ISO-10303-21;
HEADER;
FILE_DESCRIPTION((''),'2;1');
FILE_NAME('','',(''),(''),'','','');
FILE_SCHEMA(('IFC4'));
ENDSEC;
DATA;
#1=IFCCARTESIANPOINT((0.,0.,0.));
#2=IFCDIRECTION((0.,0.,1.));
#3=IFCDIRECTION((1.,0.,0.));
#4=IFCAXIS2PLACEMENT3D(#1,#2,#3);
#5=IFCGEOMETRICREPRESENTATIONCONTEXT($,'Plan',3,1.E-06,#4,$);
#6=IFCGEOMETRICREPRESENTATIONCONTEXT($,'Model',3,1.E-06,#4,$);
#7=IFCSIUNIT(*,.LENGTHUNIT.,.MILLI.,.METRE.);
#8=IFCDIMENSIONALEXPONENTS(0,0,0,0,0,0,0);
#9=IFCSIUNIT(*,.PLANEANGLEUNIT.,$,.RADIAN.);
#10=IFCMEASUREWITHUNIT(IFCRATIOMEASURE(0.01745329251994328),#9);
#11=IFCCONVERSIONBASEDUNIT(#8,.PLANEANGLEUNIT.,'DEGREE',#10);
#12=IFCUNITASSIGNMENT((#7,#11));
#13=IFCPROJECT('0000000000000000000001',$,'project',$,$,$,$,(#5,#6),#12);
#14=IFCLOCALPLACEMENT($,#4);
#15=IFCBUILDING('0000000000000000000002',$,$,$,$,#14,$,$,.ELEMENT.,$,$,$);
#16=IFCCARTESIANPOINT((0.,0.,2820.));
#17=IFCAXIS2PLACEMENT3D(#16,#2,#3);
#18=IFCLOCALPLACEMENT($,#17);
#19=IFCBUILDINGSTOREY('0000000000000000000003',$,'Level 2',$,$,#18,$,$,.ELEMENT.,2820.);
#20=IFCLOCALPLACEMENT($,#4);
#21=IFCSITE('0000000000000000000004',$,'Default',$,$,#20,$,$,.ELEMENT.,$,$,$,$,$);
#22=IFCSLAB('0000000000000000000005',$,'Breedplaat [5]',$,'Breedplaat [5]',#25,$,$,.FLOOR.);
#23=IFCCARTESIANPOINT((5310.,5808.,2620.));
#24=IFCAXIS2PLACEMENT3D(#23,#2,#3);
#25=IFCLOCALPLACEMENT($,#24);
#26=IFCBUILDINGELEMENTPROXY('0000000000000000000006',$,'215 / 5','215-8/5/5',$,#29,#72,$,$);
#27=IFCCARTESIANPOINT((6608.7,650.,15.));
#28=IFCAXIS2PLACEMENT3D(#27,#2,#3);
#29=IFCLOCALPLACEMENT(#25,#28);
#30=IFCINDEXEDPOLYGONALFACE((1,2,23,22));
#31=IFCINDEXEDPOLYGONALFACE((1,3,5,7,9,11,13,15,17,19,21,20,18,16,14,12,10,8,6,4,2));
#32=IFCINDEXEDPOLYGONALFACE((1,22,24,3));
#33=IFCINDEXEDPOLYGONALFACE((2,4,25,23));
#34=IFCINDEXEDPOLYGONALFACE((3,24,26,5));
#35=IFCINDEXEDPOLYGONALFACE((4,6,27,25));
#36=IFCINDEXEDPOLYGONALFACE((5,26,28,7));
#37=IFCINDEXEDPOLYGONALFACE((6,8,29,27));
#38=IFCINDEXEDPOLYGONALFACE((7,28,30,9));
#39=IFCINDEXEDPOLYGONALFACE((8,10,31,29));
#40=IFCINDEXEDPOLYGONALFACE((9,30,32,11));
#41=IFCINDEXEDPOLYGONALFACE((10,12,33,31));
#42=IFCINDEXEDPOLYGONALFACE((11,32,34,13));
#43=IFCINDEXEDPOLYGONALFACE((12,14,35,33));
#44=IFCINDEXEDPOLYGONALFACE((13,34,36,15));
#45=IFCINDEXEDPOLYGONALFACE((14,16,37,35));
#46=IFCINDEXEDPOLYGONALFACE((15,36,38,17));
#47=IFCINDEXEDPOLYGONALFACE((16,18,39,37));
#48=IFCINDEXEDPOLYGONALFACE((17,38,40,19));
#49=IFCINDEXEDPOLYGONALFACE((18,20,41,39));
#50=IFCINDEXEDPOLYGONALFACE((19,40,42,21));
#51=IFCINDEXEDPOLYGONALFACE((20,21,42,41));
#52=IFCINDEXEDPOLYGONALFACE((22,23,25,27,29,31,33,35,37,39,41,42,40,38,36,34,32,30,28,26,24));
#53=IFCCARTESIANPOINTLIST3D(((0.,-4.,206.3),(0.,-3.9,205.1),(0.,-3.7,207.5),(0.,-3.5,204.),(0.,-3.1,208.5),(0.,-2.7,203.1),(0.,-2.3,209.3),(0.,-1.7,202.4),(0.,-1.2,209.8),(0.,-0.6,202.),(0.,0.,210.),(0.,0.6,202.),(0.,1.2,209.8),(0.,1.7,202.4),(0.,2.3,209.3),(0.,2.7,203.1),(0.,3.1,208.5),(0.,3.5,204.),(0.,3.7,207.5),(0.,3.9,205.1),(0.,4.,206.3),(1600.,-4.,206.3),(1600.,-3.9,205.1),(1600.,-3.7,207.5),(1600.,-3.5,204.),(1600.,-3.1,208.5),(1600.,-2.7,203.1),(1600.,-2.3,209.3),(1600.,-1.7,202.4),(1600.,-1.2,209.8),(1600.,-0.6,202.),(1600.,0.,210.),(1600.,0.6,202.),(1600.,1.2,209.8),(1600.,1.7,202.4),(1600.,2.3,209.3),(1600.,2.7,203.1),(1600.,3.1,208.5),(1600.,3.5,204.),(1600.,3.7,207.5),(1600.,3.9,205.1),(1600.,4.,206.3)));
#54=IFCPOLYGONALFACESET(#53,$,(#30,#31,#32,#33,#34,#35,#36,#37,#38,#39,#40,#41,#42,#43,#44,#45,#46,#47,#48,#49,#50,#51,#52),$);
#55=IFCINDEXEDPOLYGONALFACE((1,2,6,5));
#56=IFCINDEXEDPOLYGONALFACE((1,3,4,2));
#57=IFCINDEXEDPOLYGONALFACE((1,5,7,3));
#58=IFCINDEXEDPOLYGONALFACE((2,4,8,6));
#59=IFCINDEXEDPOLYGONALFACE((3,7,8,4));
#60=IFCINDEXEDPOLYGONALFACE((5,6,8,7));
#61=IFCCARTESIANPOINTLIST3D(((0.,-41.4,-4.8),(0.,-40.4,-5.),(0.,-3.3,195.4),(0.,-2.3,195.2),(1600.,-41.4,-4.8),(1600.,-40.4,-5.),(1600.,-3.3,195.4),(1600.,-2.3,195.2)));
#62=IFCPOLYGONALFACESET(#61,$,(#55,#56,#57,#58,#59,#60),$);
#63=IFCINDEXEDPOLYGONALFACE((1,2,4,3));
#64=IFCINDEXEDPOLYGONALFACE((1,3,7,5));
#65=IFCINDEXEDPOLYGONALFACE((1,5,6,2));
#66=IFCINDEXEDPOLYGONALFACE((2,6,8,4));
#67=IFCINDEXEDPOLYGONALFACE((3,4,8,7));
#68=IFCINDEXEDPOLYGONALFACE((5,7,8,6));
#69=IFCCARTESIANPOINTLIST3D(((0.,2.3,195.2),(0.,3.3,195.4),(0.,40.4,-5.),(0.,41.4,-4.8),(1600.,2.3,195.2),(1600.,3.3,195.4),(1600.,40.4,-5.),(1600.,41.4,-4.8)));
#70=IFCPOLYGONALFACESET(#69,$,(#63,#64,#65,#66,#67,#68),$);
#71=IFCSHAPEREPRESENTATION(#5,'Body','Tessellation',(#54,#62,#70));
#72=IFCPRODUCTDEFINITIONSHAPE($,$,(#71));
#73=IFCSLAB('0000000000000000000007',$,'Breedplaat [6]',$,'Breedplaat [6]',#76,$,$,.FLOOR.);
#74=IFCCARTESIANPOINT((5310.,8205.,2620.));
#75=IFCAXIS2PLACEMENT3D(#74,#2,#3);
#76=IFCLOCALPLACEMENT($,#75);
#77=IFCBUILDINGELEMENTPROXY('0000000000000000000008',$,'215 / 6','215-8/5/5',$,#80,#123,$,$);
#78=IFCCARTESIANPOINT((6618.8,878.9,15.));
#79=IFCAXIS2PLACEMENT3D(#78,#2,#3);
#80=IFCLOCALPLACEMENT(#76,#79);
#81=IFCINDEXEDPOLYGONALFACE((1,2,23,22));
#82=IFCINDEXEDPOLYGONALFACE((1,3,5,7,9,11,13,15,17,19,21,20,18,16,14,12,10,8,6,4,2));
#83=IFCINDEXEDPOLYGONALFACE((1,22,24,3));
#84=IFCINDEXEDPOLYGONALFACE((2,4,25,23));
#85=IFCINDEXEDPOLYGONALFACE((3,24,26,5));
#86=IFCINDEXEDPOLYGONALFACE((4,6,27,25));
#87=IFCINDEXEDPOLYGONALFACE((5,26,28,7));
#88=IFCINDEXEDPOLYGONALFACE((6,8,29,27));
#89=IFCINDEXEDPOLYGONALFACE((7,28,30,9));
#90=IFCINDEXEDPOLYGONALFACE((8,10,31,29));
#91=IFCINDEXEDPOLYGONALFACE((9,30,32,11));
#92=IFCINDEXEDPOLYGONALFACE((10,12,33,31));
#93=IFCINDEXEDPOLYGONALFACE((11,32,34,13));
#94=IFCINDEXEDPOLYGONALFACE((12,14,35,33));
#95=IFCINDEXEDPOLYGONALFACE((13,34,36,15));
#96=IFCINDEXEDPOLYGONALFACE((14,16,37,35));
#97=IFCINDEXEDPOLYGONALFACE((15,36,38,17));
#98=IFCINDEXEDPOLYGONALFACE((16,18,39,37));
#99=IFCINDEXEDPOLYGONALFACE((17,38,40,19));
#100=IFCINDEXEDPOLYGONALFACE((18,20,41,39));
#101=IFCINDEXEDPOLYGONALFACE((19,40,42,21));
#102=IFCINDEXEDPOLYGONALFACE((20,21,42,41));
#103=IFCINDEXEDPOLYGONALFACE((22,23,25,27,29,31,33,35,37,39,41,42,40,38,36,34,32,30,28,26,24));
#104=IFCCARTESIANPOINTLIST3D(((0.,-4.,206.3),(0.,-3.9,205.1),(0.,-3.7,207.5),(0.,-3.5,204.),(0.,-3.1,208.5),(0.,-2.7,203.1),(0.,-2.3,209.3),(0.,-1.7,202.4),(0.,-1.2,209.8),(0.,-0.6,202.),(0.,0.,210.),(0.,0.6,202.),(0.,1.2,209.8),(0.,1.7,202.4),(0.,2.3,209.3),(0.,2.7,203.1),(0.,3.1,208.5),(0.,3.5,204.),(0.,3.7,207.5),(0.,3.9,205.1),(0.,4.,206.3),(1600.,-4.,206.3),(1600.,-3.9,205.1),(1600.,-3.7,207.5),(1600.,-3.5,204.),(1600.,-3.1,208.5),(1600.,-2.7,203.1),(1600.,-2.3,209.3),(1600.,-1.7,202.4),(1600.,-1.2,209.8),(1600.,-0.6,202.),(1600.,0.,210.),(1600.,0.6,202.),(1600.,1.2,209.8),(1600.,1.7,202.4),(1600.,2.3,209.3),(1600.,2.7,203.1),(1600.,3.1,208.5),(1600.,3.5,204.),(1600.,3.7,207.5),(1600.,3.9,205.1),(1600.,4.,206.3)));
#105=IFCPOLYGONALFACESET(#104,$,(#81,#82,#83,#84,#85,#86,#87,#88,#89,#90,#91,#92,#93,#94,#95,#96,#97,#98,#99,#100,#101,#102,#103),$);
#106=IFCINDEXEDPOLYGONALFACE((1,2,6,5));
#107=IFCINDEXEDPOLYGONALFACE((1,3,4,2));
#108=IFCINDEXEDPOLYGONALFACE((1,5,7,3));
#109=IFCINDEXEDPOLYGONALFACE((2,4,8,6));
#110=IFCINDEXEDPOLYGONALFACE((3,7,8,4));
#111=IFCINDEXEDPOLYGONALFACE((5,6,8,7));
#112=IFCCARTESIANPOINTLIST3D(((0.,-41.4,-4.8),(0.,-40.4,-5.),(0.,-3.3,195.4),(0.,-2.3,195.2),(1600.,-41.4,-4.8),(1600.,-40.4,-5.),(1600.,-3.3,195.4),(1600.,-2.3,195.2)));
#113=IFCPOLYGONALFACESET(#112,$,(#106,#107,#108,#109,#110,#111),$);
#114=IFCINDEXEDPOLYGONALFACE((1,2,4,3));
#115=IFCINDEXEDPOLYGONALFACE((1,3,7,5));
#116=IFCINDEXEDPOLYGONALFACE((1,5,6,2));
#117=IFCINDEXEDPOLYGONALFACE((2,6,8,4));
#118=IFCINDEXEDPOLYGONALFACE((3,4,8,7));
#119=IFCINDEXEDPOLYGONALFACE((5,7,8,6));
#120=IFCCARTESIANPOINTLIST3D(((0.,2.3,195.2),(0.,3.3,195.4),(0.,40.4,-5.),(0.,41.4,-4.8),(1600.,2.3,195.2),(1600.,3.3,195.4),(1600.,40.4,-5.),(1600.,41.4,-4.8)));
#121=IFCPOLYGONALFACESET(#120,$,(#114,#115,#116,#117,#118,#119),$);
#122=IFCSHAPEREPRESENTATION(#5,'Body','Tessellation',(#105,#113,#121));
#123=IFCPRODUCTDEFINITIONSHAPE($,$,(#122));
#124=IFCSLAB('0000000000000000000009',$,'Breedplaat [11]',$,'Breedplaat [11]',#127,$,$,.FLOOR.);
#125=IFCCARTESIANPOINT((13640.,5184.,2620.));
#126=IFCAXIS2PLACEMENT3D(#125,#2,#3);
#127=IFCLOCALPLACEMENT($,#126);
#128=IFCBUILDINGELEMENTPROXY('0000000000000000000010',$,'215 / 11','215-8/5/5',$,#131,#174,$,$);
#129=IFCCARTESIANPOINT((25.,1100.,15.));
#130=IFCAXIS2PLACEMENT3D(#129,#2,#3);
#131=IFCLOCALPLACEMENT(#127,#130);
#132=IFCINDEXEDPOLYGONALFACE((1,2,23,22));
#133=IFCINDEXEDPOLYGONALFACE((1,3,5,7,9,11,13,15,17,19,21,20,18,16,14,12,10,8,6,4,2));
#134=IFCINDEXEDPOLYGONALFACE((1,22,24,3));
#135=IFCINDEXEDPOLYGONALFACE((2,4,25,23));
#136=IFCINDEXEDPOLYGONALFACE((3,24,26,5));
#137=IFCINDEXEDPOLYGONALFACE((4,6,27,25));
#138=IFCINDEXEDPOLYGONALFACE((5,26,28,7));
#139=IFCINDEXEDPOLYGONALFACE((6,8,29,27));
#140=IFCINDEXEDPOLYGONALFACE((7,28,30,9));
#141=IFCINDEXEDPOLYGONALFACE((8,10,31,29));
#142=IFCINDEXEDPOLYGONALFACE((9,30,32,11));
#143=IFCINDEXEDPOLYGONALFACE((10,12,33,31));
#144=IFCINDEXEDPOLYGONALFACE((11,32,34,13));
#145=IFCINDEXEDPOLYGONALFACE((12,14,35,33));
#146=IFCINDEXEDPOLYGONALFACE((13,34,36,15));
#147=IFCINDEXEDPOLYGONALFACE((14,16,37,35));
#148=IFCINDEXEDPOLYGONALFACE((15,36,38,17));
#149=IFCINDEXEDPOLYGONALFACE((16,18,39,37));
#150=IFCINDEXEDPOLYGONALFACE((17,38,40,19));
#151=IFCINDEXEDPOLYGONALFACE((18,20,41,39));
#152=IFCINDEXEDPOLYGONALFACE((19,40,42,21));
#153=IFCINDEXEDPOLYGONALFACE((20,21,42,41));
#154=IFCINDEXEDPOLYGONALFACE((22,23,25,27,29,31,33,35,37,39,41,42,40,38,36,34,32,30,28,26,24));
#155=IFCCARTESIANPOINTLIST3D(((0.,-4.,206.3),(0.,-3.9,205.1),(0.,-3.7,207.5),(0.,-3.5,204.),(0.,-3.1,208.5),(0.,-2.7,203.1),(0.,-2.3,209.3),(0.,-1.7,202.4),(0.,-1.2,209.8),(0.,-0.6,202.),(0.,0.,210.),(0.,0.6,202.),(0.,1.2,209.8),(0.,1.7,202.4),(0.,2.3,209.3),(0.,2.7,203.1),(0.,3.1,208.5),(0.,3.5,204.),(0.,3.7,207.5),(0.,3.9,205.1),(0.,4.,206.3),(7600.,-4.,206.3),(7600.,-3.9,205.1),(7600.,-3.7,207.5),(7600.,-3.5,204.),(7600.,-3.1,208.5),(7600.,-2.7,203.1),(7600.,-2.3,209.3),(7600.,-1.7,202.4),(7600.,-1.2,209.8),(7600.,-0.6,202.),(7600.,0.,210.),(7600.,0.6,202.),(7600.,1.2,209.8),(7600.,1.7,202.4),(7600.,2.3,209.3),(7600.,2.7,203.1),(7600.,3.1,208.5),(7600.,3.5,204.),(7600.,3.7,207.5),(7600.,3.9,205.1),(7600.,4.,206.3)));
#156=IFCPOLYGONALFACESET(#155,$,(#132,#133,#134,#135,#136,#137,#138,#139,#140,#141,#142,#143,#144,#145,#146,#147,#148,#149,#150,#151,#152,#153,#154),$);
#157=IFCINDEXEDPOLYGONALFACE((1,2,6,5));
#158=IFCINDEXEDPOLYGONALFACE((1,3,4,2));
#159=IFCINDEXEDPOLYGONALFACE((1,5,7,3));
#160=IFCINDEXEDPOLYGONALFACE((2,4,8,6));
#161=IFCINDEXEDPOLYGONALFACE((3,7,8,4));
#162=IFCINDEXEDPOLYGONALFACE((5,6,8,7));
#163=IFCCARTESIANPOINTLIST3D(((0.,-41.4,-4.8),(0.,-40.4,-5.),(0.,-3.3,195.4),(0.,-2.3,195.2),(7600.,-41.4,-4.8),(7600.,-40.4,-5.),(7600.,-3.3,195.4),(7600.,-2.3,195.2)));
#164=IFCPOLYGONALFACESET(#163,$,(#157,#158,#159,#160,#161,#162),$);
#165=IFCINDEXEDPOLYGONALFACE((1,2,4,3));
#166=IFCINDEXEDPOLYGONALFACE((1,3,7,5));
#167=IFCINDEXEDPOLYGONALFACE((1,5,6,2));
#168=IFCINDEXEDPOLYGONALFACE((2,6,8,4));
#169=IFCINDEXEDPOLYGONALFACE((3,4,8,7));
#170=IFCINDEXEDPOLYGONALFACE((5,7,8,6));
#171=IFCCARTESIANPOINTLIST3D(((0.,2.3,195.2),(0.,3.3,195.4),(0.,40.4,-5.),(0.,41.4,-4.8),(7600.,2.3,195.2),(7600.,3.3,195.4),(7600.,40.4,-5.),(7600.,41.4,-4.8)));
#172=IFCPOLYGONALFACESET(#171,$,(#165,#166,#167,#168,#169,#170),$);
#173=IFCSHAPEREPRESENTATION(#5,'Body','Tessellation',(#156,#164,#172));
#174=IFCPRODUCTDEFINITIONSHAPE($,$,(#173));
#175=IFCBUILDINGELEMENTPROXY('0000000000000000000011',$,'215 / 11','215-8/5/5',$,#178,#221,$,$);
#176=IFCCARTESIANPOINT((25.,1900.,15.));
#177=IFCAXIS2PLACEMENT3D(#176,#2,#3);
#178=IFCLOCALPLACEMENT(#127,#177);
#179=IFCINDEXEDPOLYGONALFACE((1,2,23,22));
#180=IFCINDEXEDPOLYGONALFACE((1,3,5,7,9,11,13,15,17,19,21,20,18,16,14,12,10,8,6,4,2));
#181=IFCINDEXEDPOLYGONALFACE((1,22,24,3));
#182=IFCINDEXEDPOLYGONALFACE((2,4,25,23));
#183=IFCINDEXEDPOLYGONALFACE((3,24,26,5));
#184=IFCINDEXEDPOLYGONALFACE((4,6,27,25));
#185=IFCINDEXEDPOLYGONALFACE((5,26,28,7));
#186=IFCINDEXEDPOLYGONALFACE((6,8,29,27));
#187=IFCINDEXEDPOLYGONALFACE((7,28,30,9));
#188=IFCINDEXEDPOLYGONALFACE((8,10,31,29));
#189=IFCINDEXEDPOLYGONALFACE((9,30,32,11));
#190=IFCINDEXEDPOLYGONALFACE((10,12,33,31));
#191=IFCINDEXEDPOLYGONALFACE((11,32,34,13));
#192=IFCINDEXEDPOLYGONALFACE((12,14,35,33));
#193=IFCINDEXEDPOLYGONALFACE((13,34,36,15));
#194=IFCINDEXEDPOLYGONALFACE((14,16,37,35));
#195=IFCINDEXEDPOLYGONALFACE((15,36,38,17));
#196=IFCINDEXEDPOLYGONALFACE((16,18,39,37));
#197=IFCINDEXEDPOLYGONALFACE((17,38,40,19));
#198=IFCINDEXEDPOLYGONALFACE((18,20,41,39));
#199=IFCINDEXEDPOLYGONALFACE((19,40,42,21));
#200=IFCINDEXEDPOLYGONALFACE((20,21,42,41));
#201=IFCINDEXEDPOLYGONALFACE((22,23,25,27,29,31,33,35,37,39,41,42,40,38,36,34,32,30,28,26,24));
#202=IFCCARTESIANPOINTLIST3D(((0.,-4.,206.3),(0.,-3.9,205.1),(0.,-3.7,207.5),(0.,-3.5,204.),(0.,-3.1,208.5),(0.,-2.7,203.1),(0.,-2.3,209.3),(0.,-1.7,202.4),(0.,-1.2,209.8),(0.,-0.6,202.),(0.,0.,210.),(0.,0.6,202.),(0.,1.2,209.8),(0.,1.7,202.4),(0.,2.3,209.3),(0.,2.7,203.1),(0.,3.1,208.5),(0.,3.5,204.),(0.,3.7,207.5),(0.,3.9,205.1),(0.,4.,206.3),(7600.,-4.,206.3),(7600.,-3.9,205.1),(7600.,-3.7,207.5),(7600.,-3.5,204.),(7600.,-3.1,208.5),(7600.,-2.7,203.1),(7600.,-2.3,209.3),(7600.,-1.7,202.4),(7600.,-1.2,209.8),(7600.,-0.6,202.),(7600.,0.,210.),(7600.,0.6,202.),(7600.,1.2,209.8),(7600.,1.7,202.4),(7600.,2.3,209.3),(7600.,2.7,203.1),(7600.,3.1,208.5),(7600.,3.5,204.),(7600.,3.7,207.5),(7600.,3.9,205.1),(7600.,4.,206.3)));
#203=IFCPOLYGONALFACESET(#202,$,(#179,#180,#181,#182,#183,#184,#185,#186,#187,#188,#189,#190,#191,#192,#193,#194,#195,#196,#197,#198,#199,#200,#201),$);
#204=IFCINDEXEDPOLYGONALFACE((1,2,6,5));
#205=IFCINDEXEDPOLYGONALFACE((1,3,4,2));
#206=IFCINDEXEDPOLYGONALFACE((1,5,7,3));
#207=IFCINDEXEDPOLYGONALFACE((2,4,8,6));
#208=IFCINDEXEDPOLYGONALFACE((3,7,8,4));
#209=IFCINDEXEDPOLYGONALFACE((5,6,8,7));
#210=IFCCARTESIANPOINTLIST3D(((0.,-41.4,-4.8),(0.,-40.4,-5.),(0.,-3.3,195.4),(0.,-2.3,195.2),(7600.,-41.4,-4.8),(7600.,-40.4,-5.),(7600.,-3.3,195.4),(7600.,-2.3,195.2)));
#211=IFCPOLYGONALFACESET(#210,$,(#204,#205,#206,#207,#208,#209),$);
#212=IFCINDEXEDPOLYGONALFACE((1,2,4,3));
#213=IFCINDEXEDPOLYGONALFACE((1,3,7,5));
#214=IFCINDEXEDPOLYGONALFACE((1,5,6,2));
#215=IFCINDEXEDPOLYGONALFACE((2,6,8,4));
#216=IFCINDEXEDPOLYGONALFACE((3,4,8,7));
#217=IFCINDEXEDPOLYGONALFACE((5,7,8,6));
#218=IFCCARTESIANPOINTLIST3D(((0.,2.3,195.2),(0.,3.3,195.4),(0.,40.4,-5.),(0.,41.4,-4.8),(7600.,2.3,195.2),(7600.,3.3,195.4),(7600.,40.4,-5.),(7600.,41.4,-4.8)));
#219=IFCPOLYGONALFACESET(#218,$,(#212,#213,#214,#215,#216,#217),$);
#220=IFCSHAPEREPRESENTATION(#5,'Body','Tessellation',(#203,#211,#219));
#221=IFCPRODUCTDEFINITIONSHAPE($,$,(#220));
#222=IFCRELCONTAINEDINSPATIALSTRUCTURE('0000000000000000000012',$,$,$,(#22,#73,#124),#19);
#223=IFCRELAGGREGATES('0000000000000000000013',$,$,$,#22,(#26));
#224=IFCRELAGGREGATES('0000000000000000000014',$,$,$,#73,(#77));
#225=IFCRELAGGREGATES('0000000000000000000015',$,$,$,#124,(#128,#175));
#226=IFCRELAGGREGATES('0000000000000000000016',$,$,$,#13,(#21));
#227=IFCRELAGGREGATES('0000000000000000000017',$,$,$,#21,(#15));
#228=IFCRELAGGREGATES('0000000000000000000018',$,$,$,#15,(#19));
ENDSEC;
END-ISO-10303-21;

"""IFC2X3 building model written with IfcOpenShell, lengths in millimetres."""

from ifc_helpers import new_model, entity, si_unit, converted_unit, frame, origin_with_axes, origin_2d_with_axis, place, context, project, spatial, rectangle, circle, extrude, element, aggregate, save


model = new_model("IFC2X3")

# Units and contexts
plan_context = context("Plan", 3, precision=1e-06, world=origin_with_axes())
model_context = context("Model", 3, precision=1e-06, world=origin_with_axes())
ifc_project = project(units=[si_unit("LENGTHUNIT", "METRE", prefix="MILLI"), converted_unit("PLANEANGLEUNIT", "DEGREE", entity("IfcRatioMeasure", 0.01745329251994328), si_unit("PLANEANGLEUNIT", "RADIAN"), dimensions=[0, 0, 0, 0, 0, 0, 0])], contexts=[plan_context, model_context])

# Site, building, storey
site_placement = place(None, origin_with_axes())
site = spatial("IfcSite", under=ifc_project, at=site_placement, Name="Default", CompositionType="ELEMENT")
building_placement = place(None, origin_with_axes())
building = spatial("IfcBuilding", under=site, at=building_placement, CompositionType="ELEMENT")
storey_placement = place(None, frame((0.0, 0.0, 2820.0), z_axis=(0.0, 0.0, 1.0), x_axis=(1.0, 0.0, 0.0)))
storey = spatial("IfcBuildingStorey", under=building, at=storey_placement, Name="Level 2", CompositionType="ELEMENT", Elevation=2820.0)

# Slabs, building element proxies
slab_1_placement = place(None, frame((5310.0, 5808.0, 2620.0), z_axis=(0.0, 0.0, 1.0), x_axis=(1.0, 0.0, 0.0)))
slab_1 = element("IfcSlab", 1, at=slab_1_placement, inside=storey, Name="Breedplaat [5]", ObjectType="Breedplaat [5]", PredefinedType="FLOOR")
proxy_1_placement = place(slab_1_placement, frame((6608.7, 650.0, 15.0), z_axis=(0.0, 0.0, 1.0), x_axis=(1.0, 0.0, 0.0)))
proxy_1 = element("IfcBuildingElementProxy", 2, at=proxy_1_placement, Name="215 / 5", Description="215-8/5/5", context=plan_context, shape_type="SweptSolid", body=[
    extrude(circle(Radius=4.0, at=origin_2d_with_axis()), frame((0.0, 0.0, 206.0), z_axis=(1.0, 0.0, 0.0), x_axis=(0.0, 0.0, 1.0)), (0.0, 0.0, 1.0), 1600.0),
    extrude(rectangle(XDim=203.8, YDim=1.0, at=origin_2d_with_axis()), frame((0.0, -21.9, 95.2), z_axis=(1.0, 0.0, 0.0), x_axis=(0.0, 0.187112, 0.982339)), (0.0, 0.0, 1.0), 1600.0),
    extrude(rectangle(XDim=203.8, YDim=1.0, at=origin_2d_with_axis()), frame((0.0, 21.9, 95.2), z_axis=(1.0, 0.0, 0.0), x_axis=(0.0, -0.187112, 0.982339)), (0.0, 0.0, 1.0), 1600.0),
])
aggregate(slab_1, [proxy_1])
slab_2_placement = place(None, frame((5310.0, 8205.0, 2620.0), z_axis=(0.0, 0.0, 1.0), x_axis=(1.0, 0.0, 0.0)))
slab_2 = element("IfcSlab", 3, at=slab_2_placement, inside=storey, Name="Breedplaat [6]", ObjectType="Breedplaat [6]", PredefinedType="FLOOR")
proxy_2_placement = place(slab_2_placement, frame((6618.8, 878.9, 15.0), z_axis=(0.0, 0.0, 1.0), x_axis=(1.0, 0.0, 0.0)))
proxy_2 = element("IfcBuildingElementProxy", 4, at=proxy_2_placement, Name="215 / 6", Description="215-8/5/5", context=plan_context, shape_type="SweptSolid", body=[
    extrude(circle(Radius=4.0, at=origin_2d_with_axis()), frame((0.0, 0.0, 206.0), z_axis=(1.0, 0.0, 0.0), x_axis=(0.0, 0.0, 1.0)), (0.0, 0.0, 1.0), 1600.0),
    extrude(rectangle(XDim=203.8, YDim=1.0, at=origin_2d_with_axis()), frame((0.0, -21.9, 95.2), z_axis=(1.0, 0.0, 0.0), x_axis=(0.0, 0.187112, 0.982339)), (0.0, 0.0, 1.0), 1600.0),
    extrude(rectangle(XDim=203.8, YDim=1.0, at=origin_2d_with_axis()), frame((0.0, 21.9, 95.2), z_axis=(1.0, 0.0, 0.0), x_axis=(0.0, -0.187112, 0.982339)), (0.0, 0.0, 1.0), 1600.0),
])
aggregate(slab_2, [proxy_2])
slab_3_placement = place(None, frame((13640.0, 5184.0, 2620.0), z_axis=(0.0, 0.0, 1.0), x_axis=(1.0, 0.0, 0.0)))
slab_3 = element("IfcSlab", 5, at=slab_3_placement, inside=storey, Name="Breedplaat [11]", ObjectType="Breedplaat [11]", PredefinedType="FLOOR")
proxy_3_placement = place(slab_3_placement, frame((25.0, 1100.0, 15.0), z_axis=(0.0, 0.0, 1.0), x_axis=(1.0, 0.0, 0.0)))
proxy_3 = element("IfcBuildingElementProxy", 6, at=proxy_3_placement, Name="215 / 11", Description="215-8/5/5", context=plan_context, shape_type="SweptSolid", body=[
    extrude(circle(Radius=4.0, at=origin_2d_with_axis()), frame((0.0, 0.0, 206.0), z_axis=(1.0, 0.0, 0.0), x_axis=(0.0, 0.0, 1.0)), (0.0, 0.0, 1.0), 7600.0),
    extrude(rectangle(XDim=203.8, YDim=1.0, at=origin_2d_with_axis()), frame((0.0, -21.9, 95.2), z_axis=(1.0, 0.0, 0.0), x_axis=(0.0, 0.187112, 0.982339)), (0.0, 0.0, 1.0), 7600.0),
    extrude(rectangle(XDim=203.8, YDim=1.0, at=origin_2d_with_axis()), frame((0.0, 21.9, 95.2), z_axis=(1.0, 0.0, 0.0), x_axis=(0.0, -0.187112, 0.982339)), (0.0, 0.0, 1.0), 7600.0),
])
proxy_4_placement = place(slab_3_placement, frame((25.0, 1900.0, 15.0), z_axis=(0.0, 0.0, 1.0), x_axis=(1.0, 0.0, 0.0)))
proxy_4 = element("IfcBuildingElementProxy", 7, at=proxy_4_placement, Name="215 / 11", Description="215-8/5/5", context=plan_context, shape_type="SweptSolid", body=[
    extrude(circle(Radius=4.0, at=origin_2d_with_axis()), frame((0.0, 0.0, 206.0), z_axis=(1.0, 0.0, 0.0), x_axis=(0.0, 0.0, 1.0)), (0.0, 0.0, 1.0), 7600.0),
    extrude(rectangle(XDim=203.8, YDim=1.0, at=origin_2d_with_axis()), frame((0.0, -21.9, 95.2), z_axis=(1.0, 0.0, 0.0), x_axis=(0.0, 0.187112, 0.982339)), (0.0, 0.0, 1.0), 7600.0),
    extrude(rectangle(XDim=203.8, YDim=1.0, at=origin_2d_with_axis()), frame((0.0, 21.9, 95.2), z_axis=(1.0, 0.0, 0.0), x_axis=(0.0, -0.187112, 0.982339)), (0.0, 0.0, 1.0), 7600.0),
])
aggregate(slab_3, [proxy_3, proxy_4])

save(model, "model.ifc")
